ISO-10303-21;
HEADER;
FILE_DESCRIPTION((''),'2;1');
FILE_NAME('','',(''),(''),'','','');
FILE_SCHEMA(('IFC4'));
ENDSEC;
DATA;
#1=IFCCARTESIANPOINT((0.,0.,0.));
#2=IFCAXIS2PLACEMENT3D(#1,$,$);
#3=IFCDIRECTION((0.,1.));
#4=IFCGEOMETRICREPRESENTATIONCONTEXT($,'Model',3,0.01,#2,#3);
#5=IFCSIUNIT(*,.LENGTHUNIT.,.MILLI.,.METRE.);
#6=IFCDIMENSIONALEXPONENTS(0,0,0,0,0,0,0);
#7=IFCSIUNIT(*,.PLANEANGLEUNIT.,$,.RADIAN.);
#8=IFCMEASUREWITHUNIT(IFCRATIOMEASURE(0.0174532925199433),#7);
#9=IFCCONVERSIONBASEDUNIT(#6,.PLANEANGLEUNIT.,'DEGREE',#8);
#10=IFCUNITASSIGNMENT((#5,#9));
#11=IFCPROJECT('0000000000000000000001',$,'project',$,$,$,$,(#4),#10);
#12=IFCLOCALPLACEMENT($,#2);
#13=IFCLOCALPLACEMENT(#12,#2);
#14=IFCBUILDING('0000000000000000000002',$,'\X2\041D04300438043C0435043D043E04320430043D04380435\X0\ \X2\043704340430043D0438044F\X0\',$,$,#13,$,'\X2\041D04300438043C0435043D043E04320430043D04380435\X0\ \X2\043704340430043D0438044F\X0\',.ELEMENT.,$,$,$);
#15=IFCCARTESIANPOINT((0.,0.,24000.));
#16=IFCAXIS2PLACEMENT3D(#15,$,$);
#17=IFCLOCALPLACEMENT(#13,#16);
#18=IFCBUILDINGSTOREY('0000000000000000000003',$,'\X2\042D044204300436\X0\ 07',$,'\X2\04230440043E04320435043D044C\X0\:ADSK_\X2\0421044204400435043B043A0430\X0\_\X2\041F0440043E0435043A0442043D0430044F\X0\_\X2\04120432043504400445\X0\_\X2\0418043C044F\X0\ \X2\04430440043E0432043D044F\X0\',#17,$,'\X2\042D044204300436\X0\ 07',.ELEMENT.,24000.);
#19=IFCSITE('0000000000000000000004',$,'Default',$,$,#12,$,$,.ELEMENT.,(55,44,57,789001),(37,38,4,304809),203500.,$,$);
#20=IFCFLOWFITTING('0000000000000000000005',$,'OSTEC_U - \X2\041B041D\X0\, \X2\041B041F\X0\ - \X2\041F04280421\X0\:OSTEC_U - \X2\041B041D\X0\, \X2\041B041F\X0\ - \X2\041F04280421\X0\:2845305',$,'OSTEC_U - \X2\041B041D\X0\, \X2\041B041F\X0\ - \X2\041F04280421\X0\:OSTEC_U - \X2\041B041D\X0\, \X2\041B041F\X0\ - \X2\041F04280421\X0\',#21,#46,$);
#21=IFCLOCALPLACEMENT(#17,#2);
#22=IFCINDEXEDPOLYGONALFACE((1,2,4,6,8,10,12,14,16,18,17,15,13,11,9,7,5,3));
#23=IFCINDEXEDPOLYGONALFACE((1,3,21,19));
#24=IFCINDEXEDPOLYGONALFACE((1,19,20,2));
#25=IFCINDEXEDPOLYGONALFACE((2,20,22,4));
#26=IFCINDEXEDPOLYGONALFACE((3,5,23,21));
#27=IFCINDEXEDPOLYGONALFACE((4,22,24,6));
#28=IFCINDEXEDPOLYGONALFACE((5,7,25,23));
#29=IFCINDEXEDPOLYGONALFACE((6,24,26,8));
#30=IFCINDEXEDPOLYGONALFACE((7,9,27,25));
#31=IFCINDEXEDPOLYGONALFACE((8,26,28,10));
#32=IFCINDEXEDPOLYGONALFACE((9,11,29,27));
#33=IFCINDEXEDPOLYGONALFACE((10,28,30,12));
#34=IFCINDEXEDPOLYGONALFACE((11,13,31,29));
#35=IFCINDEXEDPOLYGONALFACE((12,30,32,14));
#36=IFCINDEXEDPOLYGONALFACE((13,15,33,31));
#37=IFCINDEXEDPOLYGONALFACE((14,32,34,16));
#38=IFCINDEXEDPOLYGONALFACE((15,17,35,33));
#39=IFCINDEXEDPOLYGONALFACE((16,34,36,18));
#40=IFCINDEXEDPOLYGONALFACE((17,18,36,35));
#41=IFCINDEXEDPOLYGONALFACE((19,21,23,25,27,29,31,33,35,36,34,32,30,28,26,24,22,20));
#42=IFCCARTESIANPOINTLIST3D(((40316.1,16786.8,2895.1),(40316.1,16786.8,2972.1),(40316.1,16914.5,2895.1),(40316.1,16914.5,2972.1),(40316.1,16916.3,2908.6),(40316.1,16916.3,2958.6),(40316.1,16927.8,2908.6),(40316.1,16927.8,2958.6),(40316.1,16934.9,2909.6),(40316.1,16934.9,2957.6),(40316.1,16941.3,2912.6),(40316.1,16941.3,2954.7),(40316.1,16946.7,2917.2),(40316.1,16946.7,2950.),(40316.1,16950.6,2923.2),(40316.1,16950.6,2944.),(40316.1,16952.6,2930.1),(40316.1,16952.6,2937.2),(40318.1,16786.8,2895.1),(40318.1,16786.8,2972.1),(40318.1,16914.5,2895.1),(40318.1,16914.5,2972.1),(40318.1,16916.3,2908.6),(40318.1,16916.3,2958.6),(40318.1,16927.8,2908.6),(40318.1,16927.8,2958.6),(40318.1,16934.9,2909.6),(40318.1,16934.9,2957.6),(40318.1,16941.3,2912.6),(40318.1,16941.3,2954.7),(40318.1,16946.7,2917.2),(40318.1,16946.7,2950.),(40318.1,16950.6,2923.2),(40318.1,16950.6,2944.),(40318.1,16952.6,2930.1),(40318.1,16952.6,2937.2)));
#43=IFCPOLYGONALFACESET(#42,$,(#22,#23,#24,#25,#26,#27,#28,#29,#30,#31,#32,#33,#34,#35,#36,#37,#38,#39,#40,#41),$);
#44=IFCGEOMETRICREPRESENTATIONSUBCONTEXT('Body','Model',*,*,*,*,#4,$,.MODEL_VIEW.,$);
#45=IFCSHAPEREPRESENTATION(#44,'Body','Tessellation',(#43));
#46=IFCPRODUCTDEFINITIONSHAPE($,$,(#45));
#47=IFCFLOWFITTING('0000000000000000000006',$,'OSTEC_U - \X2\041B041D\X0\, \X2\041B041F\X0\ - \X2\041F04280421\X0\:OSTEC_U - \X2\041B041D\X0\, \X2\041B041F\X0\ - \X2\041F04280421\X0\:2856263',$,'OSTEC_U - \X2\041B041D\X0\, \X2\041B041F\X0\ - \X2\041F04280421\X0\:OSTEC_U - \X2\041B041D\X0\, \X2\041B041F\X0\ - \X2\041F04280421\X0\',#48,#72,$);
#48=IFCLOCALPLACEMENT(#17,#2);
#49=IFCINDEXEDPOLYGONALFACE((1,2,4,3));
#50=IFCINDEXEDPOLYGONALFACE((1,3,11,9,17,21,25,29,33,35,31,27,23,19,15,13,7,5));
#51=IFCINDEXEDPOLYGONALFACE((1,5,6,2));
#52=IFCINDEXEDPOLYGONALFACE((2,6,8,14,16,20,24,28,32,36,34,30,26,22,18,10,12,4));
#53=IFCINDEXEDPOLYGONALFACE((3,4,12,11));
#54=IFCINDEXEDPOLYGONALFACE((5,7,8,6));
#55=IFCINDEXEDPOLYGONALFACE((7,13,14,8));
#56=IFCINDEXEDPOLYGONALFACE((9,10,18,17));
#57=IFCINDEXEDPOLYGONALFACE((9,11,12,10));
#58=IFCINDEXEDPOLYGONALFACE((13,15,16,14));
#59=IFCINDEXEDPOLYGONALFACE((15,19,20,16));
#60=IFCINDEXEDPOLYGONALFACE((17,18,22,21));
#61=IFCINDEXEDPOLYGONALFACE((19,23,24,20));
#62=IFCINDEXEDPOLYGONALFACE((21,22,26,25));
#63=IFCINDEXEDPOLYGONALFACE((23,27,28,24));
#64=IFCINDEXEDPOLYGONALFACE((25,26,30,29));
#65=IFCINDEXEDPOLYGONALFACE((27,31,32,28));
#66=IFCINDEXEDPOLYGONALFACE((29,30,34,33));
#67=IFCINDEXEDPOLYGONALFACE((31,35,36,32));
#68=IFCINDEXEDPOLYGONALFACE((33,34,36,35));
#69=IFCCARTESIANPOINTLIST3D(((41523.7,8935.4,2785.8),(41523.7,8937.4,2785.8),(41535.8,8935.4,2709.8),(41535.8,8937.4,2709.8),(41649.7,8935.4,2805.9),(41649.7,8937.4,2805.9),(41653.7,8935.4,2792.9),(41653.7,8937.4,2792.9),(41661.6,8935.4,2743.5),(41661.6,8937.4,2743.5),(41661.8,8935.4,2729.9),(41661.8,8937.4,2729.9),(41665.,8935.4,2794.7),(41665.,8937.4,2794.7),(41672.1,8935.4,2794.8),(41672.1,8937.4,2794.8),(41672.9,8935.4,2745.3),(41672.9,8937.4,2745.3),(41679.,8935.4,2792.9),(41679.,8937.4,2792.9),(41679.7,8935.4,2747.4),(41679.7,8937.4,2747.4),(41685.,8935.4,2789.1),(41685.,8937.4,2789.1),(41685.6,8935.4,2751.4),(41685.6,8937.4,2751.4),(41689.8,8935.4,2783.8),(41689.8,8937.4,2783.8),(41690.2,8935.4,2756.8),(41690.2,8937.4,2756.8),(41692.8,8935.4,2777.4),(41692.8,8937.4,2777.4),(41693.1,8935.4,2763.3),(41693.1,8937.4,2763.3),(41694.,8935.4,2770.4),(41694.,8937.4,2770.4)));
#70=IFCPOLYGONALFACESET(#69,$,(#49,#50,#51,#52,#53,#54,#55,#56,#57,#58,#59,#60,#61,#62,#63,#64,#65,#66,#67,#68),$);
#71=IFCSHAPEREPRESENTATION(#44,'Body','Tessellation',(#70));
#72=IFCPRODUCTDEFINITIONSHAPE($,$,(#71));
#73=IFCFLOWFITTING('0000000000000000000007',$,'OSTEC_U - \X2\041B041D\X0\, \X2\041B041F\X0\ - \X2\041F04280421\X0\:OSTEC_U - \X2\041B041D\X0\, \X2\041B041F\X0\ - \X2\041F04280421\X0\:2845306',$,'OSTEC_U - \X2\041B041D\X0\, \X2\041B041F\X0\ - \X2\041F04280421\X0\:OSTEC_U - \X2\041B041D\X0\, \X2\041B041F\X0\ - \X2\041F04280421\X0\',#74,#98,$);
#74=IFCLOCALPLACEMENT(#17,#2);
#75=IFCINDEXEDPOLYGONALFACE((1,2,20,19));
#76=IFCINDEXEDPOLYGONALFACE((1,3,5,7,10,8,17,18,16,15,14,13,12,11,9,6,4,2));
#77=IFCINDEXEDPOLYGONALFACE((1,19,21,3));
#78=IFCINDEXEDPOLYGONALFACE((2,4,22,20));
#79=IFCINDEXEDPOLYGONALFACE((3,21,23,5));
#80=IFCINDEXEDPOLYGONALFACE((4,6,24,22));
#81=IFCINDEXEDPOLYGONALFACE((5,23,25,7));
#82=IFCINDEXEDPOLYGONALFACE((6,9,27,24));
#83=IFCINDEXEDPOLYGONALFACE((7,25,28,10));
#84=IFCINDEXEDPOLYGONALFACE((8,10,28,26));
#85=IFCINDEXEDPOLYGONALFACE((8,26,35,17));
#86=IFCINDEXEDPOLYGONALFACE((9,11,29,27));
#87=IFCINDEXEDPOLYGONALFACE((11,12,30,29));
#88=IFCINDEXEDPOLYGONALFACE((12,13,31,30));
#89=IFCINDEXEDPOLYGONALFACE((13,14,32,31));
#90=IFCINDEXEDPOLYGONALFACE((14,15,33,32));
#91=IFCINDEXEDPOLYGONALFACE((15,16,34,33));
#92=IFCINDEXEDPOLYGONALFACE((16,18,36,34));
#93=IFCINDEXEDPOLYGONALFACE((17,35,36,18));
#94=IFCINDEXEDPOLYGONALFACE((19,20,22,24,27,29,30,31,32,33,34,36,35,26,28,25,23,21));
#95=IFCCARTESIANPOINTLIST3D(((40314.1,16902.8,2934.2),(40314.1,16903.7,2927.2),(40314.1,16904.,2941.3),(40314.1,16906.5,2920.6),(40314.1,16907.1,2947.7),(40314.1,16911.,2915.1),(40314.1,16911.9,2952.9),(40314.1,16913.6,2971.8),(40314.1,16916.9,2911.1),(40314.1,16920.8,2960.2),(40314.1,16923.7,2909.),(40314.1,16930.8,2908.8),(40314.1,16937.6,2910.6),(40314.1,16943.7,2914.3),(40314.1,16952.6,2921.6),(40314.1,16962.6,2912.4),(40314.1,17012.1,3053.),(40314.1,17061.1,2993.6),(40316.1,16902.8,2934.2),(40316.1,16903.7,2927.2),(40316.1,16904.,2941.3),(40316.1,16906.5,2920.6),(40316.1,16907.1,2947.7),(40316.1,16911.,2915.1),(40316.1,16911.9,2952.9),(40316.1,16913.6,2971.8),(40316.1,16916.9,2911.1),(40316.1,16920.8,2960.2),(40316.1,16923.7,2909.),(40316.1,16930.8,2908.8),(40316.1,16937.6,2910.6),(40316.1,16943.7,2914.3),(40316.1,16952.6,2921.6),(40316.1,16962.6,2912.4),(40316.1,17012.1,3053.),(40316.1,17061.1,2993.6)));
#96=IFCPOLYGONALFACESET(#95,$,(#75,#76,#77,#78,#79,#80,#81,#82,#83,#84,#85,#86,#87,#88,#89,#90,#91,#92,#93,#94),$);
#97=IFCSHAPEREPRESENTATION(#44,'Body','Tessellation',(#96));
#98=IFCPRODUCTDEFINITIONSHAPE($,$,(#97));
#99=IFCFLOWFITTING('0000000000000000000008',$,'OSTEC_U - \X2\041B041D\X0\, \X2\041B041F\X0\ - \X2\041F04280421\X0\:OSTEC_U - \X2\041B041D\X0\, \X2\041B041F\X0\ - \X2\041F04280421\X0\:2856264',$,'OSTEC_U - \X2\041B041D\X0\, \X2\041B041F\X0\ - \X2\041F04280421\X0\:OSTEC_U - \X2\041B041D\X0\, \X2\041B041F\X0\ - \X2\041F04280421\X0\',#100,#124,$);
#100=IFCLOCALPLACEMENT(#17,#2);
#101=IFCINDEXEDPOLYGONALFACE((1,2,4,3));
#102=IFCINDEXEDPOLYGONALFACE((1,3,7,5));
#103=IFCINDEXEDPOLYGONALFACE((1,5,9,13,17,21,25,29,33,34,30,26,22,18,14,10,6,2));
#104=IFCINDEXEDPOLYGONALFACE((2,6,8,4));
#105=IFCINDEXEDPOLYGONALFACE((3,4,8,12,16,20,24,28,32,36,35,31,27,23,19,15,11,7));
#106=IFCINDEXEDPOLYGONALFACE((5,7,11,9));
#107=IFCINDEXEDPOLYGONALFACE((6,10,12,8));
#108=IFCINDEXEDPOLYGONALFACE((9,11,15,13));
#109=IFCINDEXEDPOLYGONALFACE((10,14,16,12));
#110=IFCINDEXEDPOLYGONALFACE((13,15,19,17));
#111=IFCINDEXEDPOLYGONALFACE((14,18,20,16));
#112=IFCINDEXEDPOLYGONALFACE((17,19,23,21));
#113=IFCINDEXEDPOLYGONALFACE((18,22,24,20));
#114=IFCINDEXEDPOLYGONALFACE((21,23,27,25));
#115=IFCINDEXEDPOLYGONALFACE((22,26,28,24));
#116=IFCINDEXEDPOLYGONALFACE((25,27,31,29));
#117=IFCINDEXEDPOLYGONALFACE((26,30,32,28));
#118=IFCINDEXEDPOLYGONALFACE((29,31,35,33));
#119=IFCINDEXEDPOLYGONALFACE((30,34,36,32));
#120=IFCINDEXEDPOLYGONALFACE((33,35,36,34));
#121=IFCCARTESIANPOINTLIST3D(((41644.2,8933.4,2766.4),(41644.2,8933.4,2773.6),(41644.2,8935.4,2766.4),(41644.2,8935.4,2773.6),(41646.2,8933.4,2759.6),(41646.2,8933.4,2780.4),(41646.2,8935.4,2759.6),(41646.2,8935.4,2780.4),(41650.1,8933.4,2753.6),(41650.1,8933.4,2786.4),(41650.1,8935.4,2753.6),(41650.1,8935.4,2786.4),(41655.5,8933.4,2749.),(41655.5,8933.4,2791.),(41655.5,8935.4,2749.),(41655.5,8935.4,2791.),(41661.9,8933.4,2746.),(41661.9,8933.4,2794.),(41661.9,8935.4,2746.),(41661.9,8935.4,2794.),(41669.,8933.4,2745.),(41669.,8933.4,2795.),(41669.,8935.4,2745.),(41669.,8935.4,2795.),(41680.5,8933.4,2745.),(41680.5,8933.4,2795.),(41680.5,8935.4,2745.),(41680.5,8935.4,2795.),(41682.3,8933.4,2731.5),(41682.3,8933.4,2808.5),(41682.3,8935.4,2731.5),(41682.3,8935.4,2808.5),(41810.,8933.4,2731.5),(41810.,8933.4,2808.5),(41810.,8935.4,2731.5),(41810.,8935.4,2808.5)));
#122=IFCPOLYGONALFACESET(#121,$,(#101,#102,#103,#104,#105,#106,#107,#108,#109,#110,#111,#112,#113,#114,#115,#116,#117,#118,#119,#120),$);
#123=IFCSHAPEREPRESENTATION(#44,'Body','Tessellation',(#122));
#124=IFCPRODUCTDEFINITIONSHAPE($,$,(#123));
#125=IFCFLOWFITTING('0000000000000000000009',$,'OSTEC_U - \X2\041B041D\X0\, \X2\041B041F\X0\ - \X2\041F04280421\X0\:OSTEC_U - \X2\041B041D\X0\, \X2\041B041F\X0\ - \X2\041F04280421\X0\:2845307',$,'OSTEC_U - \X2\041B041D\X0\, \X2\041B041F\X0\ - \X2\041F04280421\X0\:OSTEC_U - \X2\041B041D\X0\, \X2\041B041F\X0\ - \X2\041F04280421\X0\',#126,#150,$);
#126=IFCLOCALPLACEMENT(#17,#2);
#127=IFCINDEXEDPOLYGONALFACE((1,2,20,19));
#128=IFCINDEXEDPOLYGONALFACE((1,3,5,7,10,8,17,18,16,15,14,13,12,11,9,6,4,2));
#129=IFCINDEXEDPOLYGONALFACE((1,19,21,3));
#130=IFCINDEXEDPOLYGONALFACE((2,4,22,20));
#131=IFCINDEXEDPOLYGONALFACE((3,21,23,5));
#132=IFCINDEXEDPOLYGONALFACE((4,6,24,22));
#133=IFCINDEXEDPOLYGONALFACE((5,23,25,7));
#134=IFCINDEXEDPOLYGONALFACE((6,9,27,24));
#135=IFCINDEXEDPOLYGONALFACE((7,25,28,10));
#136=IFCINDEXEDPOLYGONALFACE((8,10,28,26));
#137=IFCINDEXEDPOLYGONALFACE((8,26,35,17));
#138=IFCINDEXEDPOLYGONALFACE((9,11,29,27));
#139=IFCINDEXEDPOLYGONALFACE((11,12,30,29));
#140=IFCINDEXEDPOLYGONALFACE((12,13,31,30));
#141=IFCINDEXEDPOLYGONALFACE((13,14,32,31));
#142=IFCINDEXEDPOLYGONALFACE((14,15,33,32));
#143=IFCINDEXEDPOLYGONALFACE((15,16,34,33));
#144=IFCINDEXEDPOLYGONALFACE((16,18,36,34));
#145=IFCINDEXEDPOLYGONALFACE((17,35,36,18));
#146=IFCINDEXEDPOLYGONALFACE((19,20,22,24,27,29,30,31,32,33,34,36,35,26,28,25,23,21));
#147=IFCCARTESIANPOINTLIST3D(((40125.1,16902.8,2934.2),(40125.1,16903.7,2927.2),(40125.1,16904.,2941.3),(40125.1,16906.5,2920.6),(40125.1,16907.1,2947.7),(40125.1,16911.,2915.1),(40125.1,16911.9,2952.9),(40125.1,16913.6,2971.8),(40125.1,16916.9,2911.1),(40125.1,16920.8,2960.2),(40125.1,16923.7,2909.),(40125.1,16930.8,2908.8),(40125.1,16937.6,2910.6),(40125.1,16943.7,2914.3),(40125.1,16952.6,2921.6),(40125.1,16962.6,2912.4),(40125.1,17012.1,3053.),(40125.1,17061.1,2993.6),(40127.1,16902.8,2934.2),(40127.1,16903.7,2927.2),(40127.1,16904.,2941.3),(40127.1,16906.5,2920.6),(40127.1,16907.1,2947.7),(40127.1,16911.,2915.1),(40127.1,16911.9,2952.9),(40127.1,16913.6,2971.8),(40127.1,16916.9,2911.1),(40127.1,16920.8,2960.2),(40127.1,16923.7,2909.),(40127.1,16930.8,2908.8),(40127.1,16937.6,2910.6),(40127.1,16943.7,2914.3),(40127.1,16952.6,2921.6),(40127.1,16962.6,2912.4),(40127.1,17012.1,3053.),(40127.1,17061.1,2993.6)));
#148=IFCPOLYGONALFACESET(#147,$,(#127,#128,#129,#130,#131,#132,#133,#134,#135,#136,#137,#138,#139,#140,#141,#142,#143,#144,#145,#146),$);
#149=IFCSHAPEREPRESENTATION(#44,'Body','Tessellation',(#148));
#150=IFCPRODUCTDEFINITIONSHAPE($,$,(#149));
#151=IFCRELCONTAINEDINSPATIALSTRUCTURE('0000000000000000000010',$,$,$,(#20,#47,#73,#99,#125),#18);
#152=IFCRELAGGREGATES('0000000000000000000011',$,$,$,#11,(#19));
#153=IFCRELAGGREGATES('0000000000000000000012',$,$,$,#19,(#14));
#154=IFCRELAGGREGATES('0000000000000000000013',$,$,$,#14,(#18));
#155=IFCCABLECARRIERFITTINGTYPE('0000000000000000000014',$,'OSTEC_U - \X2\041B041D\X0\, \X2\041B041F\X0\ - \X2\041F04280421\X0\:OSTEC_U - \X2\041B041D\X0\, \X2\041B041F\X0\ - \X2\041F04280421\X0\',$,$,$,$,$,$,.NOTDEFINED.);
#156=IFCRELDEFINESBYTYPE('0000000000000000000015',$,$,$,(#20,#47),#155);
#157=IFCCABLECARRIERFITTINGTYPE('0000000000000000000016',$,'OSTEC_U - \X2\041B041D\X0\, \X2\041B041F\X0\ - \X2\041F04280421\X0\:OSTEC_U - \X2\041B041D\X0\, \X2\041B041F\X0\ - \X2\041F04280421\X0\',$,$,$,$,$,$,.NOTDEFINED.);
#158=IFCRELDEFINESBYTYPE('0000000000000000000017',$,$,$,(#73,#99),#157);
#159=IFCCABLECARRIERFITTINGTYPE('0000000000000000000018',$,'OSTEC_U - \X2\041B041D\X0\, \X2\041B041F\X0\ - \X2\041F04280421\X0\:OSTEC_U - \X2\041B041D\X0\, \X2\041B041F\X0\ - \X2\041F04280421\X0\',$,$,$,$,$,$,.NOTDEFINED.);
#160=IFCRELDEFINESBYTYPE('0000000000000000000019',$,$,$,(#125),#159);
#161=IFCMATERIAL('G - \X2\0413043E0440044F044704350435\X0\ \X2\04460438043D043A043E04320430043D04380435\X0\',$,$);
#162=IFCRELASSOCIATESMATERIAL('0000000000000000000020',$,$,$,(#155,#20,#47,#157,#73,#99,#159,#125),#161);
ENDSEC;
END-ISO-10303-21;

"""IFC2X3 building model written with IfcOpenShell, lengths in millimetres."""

from ifc_helpers import new_model, entity, si_unit, converted_unit, direction, frame, frame_2d, origin, place, context, subcontext, project, spatial, polyline, circle_curve, parameter, trimmed, segment, composite_curve, outline, extrude, source, transform, mapped, material, type_object, type_shapes, element, save


model = new_model("IFC2X3")

# Units and contexts
model_context = context("Model", 3, precision=0.01, world=origin(), true_north=direction((0.0, 1.0)))
body_context = subcontext(model_context, "Body", "Model", "MODEL_VIEW")
ifc_project = project(units=[si_unit("LENGTHUNIT", "METRE", prefix="MILLI"), converted_unit("PLANEANGLEUNIT", "DEGREE", entity("IfcRatioMeasure", 0.0174532925199433), si_unit("PLANEANGLEUNIT", "RADIAN"), dimensions=[0, 0, 0, 0, 0, 0, 0])], contexts=[model_context])

# Site, building, storey
site_placement = place(None, frame((0.0, 0.0, 0.0)))
site = spatial("IfcSite", under=ifc_project, at=site_placement, Name="Default", CompositionType="ELEMENT", RefLatitude=(55, 44, 57, 789001), RefLongitude=(37, 38, 4, 304809), RefElevation=203500.0)
building_placement = place(site_placement, origin())
building = spatial("IfcBuilding", under=site, at=building_placement, Name="Наименование здания", LongName="Наименование здания", CompositionType="ELEMENT")
storey_placement = place(building_placement, frame((0.0, 0.0, 24000.0)))
storey = spatial("IfcBuildingStorey", under=building, at=storey_placement, Name="Этаж 07", ObjectType="Уровень:ADSK_Стрелка_Проектная_Вверх_Имя уровня", LongName="Этаж 07", CompositionType="ELEMENT", Elevation=24000.0)

# Flow fittings
ifc_material_1 = material(Name="G - Горячее цинкование")
cable_carrier_fitting_type_1 = type_object("IfcCableCarrierFittingType", Name="OSTEC_U - ЛН, ЛП - ПШС:OSTEC_U - ЛН, ЛП - ПШС", PredefinedType="NOTDEFINED", material=ifc_material_1)
shared_shape_1 = source(origin(), body_context, "Body", "SweptSolid", [
    extrude(outline(composite_curve([segment(trimmed(circle_curve(frame_2d((-41.5, 0.0), x_axis=(1.0, 0.0)), 25.0), [parameter(90.0)], [parameter(270.0)], True, "PARAMETER"), True, "CONTINUOUS"), segment(polyline([(-41.5, -25.0), (-30.0, -25.0)]), True, "CONTINUOUS"), segment(polyline([(-30.0, -25.0), (-28.1, -38.5)]), True, "CONTINUOUS"), segment(polyline([(-28.1, -38.5), (99.5, -38.5)]), True, "CONTINUOUS"), segment(polyline([(99.5, -38.5), (99.5, 38.5)]), True, "CONTINUOUS"), segment(polyline([(99.5, 38.5), (-28.1, 38.5)]), True, "CONTINUOUS"), segment(polyline([(-28.1, 38.5), (-30.0, 25.0)]), True, "CONTINUOUS"), segment(polyline([(-30.0, 25.0), (-41.5, 25.0)]), True, "CONTINUOUS")], self_intersect=False)), frame((41.5, 0.0, 0.0)), (0.0, 0.0, 1.0), 2.0),
])
type_shapes(cable_carrier_fitting_type_1, [shared_shape_1])
for number, where, z_axis, x_axis, name in (
    (1, (40316.1, 16927.8, 2933.6), (1.0, 0.0, 0.0), (0.0, -1.0, 0.0), "OSTEC_U - ЛН, ЛП - ПШС:OSTEC_U - ЛН, ЛП - ПШС:2845305"),
    (2, (41669.0, 8935.4, 2770.0), (0.0, 1.0, 0.0), (-0.987499, 0.0, -0.157627), "OSTEC_U - ЛН, ЛП - ПШС:OSTEC_U - ЛН, ЛП - ПШС:2856263"),
):
    element("IfcFlowFitting", number, at=place(storey_placement, frame(where, z_axis=z_axis, x_axis=x_axis)), inside=storey, type_object=cable_carrier_fitting_type_1, material=ifc_material_1, Name=name, ObjectType="OSTEC_U - ЛН, ЛП - ПШС:OSTEC_U - ЛН, ЛП - ПШС", context=body_context, shape_type="MappedRepresentation", body=[
        mapped(shared_shape_1, transform((0.0, 0.0, 0.0), scale=1.0)),
    ])
cable_carrier_fitting_type_2 = type_object("IfcCableCarrierFittingType", Name="OSTEC_U - ЛН, ЛП - ПШС:OSTEC_U - ЛН, ЛП - ПШС", PredefinedType="NOTDEFINED", material=ifc_material_1)
shared_shape_2 = source(origin(), body_context, "Body", "SweptSolid", [
    extrude(outline(composite_curve([segment(trimmed(circle_curve(frame_2d((-41.5, 0.0), x_axis=(1.0, 0.0)), 25.0), [parameter(90.0)], [parameter(270.0)], True, "PARAMETER"), True, "CONTINUOUS"), segment(polyline([(-41.5, -25.0), (-30.0, -25.0)]), True, "CONTINUOUS"), segment(polyline([(-30.0, -25.0), (-28.1, -38.5)]), True, "CONTINUOUS"), segment(polyline([(-28.1, -38.5), (99.5, -38.5)]), True, "CONTINUOUS"), segment(polyline([(99.5, -38.5), (99.5, 38.5)]), True, "CONTINUOUS"), segment(polyline([(99.5, 38.5), (-28.1, 38.5)]), True, "CONTINUOUS"), segment(polyline([(-28.1, 38.5), (-30.0, 25.0)]), True, "CONTINUOUS"), segment(polyline([(-30.0, 25.0), (-41.5, 25.0)]), True, "CONTINUOUS")], self_intersect=False)), frame((41.5, 0.0, 0.0), z_axis=(0.0, 0.0, -1.0), x_axis=(1.0, 0.0, 0.0)), (0.0, 0.0, -1.0), 2.0),
])
type_shapes(cable_carrier_fitting_type_2, [shared_shape_2])
for number, where, z_axis, x_axis, name in (
    (3, (40314.1, 16927.8, 2933.6), (1.0, 0.0, 0.0), (0.0, 0.771695, 0.635992), "OSTEC_U - ЛН, ЛП - ПШС:OSTEC_U - ЛН, ЛП - ПШС:2845306"),
    (4, (41669.0, 8933.4, 2770.0), (0.0, 1.0, 0.0), (1.0, 0.0, 0.0), "OSTEC_U - ЛН, ЛП - ПШС:OSTEC_U - ЛН, ЛП - ПШС:2856264"),
):
    element("IfcFlowFitting", number, at=place(storey_placement, frame(where, z_axis=z_axis, x_axis=x_axis)), inside=storey, type_object=cable_carrier_fitting_type_2, material=ifc_material_1, Name=name, ObjectType="OSTEC_U - ЛН, ЛП - ПШС:OSTEC_U - ЛН, ЛП - ПШС", context=body_context, shape_type="MappedRepresentation", body=[
        mapped(shared_shape_2, transform((0.0, 0.0, 0.0), scale=1.0)),
    ])
cable_carrier_fitting_type_3 = type_object("IfcCableCarrierFittingType", Name="OSTEC_U - ЛН, ЛП - ПШС:OSTEC_U - ЛН, ЛП - ПШС", PredefinedType="NOTDEFINED", material=ifc_material_1)
shared_shape_3 = source(origin(), body_context, "Body", "SweptSolid", [
    extrude(outline(composite_curve([segment(trimmed(circle_curve(frame_2d((-41.5, 0.0), x_axis=(1.0, 0.0)), 25.0), [parameter(90.0)], [parameter(270.0)], True, "PARAMETER"), True, "CONTINUOUS"), segment(polyline([(-41.5, -25.0), (-30.0, -25.0)]), True, "CONTINUOUS"), segment(polyline([(-30.0, -25.0), (-28.1, -38.5)]), True, "CONTINUOUS"), segment(polyline([(-28.1, -38.5), (99.5, -38.5)]), True, "CONTINUOUS"), segment(polyline([(99.5, -38.5), (99.5, 38.5)]), True, "CONTINUOUS"), segment(polyline([(99.5, 38.5), (-28.1, 38.5)]), True, "CONTINUOUS"), segment(polyline([(-28.1, 38.5), (-30.0, 25.0)]), True, "CONTINUOUS"), segment(polyline([(-30.0, 25.0), (-41.5, 25.0)]), True, "CONTINUOUS")], self_intersect=False)), frame((41.5, 0.0, 0.0)), (0.0, 0.0, 1.0), 2.0),
])
type_shapes(cable_carrier_fitting_type_3, [shared_shape_3])
flow_fitting_1_placement = place(storey_placement, frame((40127.1, 16927.8, 2933.6), z_axis=(-1.0, 0.0, 0.0), x_axis=(0.0, 0.771695, 0.635992)))
element("IfcFlowFitting", 5, at=flow_fitting_1_placement, inside=storey, type_object=cable_carrier_fitting_type_3, material=ifc_material_1, Name="OSTEC_U - ЛН, ЛП - ПШС:OSTEC_U - ЛН, ЛП - ПШС:2845307", ObjectType="OSTEC_U - ЛН, ЛП - ПШС:OSTEC_U - ЛН, ЛП - ПШС", context=body_context, shape_type="MappedRepresentation", body=[
    mapped(shared_shape_3, transform((0.0, 0.0, 0.0), scale=1.0)),
])

save(model, "model.ifc")
